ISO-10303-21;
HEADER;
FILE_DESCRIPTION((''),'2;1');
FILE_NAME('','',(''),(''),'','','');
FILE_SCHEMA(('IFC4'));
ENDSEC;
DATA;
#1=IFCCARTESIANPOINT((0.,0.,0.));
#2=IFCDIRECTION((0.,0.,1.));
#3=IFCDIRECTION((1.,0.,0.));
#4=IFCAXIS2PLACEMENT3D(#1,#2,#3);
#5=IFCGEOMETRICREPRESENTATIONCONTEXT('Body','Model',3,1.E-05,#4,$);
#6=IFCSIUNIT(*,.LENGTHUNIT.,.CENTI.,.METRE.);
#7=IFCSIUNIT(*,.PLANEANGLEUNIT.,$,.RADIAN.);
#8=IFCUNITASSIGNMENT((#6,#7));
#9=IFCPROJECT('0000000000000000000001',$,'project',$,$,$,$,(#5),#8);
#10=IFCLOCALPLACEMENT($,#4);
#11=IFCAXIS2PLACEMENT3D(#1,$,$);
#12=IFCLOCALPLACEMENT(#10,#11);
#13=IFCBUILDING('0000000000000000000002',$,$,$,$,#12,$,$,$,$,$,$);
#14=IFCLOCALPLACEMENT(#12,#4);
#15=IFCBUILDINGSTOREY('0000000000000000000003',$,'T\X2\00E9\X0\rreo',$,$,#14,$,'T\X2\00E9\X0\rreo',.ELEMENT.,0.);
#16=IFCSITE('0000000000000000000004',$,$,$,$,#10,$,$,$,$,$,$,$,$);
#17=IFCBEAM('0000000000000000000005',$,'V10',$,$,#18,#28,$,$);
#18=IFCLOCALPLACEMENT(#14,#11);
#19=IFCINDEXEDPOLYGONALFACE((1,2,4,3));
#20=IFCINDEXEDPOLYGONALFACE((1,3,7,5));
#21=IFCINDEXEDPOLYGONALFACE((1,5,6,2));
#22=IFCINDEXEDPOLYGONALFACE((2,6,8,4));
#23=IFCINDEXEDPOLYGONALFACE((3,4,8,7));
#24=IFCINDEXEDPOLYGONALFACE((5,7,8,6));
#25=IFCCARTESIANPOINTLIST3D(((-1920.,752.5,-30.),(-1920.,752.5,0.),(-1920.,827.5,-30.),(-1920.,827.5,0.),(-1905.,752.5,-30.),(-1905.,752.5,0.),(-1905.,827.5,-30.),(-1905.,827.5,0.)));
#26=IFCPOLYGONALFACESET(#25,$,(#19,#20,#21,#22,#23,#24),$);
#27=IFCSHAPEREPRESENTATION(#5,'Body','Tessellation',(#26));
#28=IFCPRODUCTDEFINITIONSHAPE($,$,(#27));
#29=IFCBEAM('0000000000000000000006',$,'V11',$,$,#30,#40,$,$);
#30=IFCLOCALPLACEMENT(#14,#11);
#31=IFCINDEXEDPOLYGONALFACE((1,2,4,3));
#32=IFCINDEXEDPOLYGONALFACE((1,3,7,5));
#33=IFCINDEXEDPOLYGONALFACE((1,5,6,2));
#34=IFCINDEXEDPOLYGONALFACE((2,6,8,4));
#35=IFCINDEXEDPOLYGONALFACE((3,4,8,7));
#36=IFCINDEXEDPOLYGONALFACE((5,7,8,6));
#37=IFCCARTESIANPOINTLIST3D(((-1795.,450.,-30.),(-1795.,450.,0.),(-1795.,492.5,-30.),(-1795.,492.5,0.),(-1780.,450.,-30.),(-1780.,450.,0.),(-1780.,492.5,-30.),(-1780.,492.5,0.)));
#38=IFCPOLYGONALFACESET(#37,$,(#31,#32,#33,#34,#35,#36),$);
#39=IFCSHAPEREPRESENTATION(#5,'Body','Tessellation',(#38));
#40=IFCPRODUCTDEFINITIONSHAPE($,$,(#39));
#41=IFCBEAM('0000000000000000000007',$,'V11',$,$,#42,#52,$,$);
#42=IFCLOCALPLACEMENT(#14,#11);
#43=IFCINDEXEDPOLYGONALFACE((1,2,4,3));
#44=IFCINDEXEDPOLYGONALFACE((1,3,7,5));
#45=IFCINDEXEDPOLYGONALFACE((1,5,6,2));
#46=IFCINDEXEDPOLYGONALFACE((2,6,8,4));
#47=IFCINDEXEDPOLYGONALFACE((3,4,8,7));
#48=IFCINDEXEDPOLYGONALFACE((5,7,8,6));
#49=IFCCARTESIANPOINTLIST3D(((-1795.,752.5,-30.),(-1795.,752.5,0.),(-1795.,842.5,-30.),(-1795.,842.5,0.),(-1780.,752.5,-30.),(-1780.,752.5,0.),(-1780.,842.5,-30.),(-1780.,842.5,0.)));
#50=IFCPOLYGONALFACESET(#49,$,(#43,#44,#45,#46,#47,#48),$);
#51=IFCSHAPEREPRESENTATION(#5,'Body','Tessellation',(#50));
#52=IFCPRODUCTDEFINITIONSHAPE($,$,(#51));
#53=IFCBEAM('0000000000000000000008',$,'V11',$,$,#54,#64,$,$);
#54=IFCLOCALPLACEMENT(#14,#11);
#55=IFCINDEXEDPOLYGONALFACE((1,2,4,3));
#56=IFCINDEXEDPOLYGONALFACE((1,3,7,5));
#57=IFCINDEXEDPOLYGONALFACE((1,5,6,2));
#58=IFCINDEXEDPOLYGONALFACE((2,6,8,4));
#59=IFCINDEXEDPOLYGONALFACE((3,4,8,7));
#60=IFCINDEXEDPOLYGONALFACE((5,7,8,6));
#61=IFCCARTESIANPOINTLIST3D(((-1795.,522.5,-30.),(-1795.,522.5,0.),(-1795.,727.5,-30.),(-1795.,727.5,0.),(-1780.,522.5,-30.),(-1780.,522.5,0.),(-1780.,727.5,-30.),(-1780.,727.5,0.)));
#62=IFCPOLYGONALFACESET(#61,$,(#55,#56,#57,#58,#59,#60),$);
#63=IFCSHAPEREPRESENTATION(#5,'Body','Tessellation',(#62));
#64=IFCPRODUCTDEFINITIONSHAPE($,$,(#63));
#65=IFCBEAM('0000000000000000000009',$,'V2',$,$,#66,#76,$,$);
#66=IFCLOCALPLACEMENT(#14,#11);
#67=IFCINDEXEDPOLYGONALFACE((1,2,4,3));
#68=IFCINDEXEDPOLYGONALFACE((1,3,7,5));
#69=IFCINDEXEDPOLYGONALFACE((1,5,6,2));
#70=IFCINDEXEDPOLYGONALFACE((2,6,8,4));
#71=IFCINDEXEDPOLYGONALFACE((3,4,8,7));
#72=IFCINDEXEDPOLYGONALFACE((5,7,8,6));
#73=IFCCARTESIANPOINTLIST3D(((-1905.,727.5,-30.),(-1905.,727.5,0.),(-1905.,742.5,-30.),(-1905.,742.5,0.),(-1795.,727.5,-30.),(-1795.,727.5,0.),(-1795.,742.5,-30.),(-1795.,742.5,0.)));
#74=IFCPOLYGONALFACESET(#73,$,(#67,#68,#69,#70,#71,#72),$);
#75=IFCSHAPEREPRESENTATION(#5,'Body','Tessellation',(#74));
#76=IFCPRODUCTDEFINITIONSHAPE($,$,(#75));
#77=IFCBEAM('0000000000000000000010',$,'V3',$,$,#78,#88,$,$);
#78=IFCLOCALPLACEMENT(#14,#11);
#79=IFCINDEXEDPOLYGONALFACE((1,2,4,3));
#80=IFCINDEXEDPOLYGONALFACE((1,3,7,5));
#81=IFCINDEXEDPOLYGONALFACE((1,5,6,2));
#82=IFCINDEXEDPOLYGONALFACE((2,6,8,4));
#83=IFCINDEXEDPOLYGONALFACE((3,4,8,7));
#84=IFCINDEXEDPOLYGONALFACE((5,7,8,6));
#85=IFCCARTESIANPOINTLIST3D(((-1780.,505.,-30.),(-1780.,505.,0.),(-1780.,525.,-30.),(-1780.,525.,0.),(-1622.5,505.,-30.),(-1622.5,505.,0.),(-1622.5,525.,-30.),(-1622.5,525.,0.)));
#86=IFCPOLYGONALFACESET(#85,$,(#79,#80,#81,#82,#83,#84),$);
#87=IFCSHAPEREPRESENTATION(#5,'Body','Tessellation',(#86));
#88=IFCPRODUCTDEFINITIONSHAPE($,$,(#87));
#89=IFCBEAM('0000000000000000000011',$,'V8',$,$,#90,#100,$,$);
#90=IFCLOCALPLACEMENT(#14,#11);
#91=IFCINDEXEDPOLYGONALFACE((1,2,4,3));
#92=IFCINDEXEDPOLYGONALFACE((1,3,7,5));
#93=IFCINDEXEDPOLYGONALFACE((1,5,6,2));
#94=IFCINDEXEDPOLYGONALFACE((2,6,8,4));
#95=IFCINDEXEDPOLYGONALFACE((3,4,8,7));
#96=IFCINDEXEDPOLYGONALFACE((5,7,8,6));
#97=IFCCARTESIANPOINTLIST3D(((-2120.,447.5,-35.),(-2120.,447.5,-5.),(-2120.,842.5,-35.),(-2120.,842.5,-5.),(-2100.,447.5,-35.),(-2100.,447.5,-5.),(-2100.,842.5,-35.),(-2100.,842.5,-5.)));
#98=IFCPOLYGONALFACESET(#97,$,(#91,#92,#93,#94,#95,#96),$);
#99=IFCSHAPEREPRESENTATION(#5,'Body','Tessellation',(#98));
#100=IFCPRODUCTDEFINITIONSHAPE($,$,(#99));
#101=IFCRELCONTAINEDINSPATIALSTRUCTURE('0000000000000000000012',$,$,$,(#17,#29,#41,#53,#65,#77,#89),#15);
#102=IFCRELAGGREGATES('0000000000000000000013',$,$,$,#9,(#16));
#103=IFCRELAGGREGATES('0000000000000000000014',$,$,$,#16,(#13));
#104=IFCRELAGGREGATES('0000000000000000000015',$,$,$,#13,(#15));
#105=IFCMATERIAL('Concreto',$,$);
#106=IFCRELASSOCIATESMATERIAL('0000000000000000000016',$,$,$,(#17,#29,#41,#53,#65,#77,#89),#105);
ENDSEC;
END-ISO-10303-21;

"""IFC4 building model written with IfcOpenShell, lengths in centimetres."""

from ifc_helpers import new_model, si_unit, frame, origin, origin_with_axes, origin_2d_with_axis, place, context, project, spatial, rectangle, extrude, material, element, save


model = new_model("IFC4")

# Units and contexts
model_context = context("Model", 3, precision=1e-05, world=origin_with_axes(), identifier="Body")
ifc_project = project(units=[si_unit("LENGTHUNIT", "METRE", prefix="CENTI"), si_unit("PLANEANGLEUNIT", "RADIAN")], contexts=[model_context])

# Site, building, storey
site_placement = place(None, origin_with_axes())
site = spatial("IfcSite", under=ifc_project, at=site_placement)
building_placement = place(site_placement, origin())
building = spatial("IfcBuilding", under=site, at=building_placement)
storey_placement = place(building_placement, origin_with_axes())
storey = spatial("IfcBuildingStorey", under=building, at=storey_placement, Name="Térreo", LongName="Térreo", CompositionType="ELEMENT", Elevation=0.0)

# Shared definitions
ifc_material = material(Name="Concreto")

# Beams
beam_1_placement = place(storey_placement, frame((-1912.5, 790.0, 0.0), z_axis=(0.0, 0.0, 1.0), x_axis=(1.0, 0.0, 0.0)))
element("IfcBeam", 1, at=beam_1_placement, inside=storey, material=ifc_material, Name="V10", context=model_context, shape_type="SolidModel", body=[
    extrude(rectangle(XDim=15.0, YDim=30.0, at=origin_2d_with_axis()), frame((0.0, -37.5, -15.0), z_axis=(0.0, 1.0, 0.0), x_axis=(-1.0, 0.0, 0.0)), (0.0, 0.0, 1.0), 75.0),
])
beam_2_placement = place(storey_placement, frame((-1787.5, 471.25, 0.0), z_axis=(0.0, 0.0, 1.0), x_axis=(1.0, 0.0, 0.0)))
element("IfcBeam", 2, at=beam_2_placement, inside=storey, material=ifc_material, Name="V11", context=model_context, shape_type="SolidModel", body=[
    extrude(rectangle(XDim=15.0, YDim=30.0, at=origin_2d_with_axis()), frame((0.0, -21.25, -15.0), z_axis=(0.0, 1.0, 0.0), x_axis=(-1.0, 0.0, 0.0)), (0.0, 0.0, 1.0), 42.5),
])
beam_3_placement = place(storey_placement, frame((-1787.5, 797.5, 0.0), z_axis=(0.0, 0.0, 1.0), x_axis=(1.0, 0.0, 0.0)))
element("IfcBeam", 3, at=beam_3_placement, inside=storey, material=ifc_material, Name="V11", context=model_context, shape_type="SolidModel", body=[
    extrude(rectangle(XDim=15.0, YDim=30.0, at=origin_2d_with_axis()), frame((0.0, -45.0, -15.0), z_axis=(0.0, 1.0, 0.0), x_axis=(-1.0, 0.0, 0.0)), (0.0, 0.0, 1.0), 90.0),
])
beam_4_placement = place(storey_placement, frame((-1787.5, 625.0, 0.0), z_axis=(0.0, 0.0, 1.0), x_axis=(1.0, 0.0, 0.0)))
element("IfcBeam", 4, at=beam_4_placement, inside=storey, material=ifc_material, Name="V11", context=model_context, shape_type="SolidModel", body=[
    extrude(rectangle(XDim=15.0, YDim=30.0, at=origin_2d_with_axis()), frame((0.0, -102.5, -15.0), z_axis=(0.0, 1.0, 0.0), x_axis=(-1.0, 0.0, 0.0)), (0.0, 0.0, 1.0), 205.0),
])
beam_5_placement = place(storey_placement, frame((-1850.0, 735.0, 0.0), z_axis=(0.0, 0.0, 1.0), x_axis=(1.0, 0.0, 0.0)))
element("IfcBeam", 5, at=beam_5_placement, inside=storey, material=ifc_material, Name="V2", context=model_context, shape_type="SolidModel", body=[
    extrude(rectangle(XDim=15.0, YDim=30.0, at=origin_2d_with_axis()), frame((-55.0, 0.0, -15.0), z_axis=(1.0, 0.0, 0.0), x_axis=(0.0, -1.0, 0.0)), (0.0, 0.0, 1.0), 110.0),
])
beam_6_placement = place(storey_placement, frame((-1701.25, 515.0, 0.0), z_axis=(0.0, 0.0, 1.0), x_axis=(1.0, 0.0, 0.0)))
element("IfcBeam", 6, at=beam_6_placement, inside=storey, material=ifc_material, Name="V3", context=model_context, shape_type="SolidModel", body=[
    extrude(rectangle(XDim=20.0, YDim=30.0, at=origin_2d_with_axis()), frame((-78.75, 0.0, -15.0), z_axis=(1.0, 0.0, 0.0), x_axis=(0.0, -1.0, 0.0)), (0.0, 0.0, 1.0), 157.5),
])
beam_7_placement = place(storey_placement, frame((-2110.0, 645.0, -5.0), z_axis=(0.0, 0.0, 1.0), x_axis=(1.0, 0.0, 0.0)))
element("IfcBeam", 7, at=beam_7_placement, inside=storey, material=ifc_material, Name="V8", context=model_context, shape_type="SolidModel", body=[
    extrude(rectangle(XDim=20.0, YDim=30.0, at=origin_2d_with_axis()), frame((0.0, -197.5, -15.0), z_axis=(0.0, 1.0, 0.0), x_axis=(-1.0, 0.0, 0.0)), (0.0, 0.0, 1.0), 395.0),
])

save(model, "model.ifc")
